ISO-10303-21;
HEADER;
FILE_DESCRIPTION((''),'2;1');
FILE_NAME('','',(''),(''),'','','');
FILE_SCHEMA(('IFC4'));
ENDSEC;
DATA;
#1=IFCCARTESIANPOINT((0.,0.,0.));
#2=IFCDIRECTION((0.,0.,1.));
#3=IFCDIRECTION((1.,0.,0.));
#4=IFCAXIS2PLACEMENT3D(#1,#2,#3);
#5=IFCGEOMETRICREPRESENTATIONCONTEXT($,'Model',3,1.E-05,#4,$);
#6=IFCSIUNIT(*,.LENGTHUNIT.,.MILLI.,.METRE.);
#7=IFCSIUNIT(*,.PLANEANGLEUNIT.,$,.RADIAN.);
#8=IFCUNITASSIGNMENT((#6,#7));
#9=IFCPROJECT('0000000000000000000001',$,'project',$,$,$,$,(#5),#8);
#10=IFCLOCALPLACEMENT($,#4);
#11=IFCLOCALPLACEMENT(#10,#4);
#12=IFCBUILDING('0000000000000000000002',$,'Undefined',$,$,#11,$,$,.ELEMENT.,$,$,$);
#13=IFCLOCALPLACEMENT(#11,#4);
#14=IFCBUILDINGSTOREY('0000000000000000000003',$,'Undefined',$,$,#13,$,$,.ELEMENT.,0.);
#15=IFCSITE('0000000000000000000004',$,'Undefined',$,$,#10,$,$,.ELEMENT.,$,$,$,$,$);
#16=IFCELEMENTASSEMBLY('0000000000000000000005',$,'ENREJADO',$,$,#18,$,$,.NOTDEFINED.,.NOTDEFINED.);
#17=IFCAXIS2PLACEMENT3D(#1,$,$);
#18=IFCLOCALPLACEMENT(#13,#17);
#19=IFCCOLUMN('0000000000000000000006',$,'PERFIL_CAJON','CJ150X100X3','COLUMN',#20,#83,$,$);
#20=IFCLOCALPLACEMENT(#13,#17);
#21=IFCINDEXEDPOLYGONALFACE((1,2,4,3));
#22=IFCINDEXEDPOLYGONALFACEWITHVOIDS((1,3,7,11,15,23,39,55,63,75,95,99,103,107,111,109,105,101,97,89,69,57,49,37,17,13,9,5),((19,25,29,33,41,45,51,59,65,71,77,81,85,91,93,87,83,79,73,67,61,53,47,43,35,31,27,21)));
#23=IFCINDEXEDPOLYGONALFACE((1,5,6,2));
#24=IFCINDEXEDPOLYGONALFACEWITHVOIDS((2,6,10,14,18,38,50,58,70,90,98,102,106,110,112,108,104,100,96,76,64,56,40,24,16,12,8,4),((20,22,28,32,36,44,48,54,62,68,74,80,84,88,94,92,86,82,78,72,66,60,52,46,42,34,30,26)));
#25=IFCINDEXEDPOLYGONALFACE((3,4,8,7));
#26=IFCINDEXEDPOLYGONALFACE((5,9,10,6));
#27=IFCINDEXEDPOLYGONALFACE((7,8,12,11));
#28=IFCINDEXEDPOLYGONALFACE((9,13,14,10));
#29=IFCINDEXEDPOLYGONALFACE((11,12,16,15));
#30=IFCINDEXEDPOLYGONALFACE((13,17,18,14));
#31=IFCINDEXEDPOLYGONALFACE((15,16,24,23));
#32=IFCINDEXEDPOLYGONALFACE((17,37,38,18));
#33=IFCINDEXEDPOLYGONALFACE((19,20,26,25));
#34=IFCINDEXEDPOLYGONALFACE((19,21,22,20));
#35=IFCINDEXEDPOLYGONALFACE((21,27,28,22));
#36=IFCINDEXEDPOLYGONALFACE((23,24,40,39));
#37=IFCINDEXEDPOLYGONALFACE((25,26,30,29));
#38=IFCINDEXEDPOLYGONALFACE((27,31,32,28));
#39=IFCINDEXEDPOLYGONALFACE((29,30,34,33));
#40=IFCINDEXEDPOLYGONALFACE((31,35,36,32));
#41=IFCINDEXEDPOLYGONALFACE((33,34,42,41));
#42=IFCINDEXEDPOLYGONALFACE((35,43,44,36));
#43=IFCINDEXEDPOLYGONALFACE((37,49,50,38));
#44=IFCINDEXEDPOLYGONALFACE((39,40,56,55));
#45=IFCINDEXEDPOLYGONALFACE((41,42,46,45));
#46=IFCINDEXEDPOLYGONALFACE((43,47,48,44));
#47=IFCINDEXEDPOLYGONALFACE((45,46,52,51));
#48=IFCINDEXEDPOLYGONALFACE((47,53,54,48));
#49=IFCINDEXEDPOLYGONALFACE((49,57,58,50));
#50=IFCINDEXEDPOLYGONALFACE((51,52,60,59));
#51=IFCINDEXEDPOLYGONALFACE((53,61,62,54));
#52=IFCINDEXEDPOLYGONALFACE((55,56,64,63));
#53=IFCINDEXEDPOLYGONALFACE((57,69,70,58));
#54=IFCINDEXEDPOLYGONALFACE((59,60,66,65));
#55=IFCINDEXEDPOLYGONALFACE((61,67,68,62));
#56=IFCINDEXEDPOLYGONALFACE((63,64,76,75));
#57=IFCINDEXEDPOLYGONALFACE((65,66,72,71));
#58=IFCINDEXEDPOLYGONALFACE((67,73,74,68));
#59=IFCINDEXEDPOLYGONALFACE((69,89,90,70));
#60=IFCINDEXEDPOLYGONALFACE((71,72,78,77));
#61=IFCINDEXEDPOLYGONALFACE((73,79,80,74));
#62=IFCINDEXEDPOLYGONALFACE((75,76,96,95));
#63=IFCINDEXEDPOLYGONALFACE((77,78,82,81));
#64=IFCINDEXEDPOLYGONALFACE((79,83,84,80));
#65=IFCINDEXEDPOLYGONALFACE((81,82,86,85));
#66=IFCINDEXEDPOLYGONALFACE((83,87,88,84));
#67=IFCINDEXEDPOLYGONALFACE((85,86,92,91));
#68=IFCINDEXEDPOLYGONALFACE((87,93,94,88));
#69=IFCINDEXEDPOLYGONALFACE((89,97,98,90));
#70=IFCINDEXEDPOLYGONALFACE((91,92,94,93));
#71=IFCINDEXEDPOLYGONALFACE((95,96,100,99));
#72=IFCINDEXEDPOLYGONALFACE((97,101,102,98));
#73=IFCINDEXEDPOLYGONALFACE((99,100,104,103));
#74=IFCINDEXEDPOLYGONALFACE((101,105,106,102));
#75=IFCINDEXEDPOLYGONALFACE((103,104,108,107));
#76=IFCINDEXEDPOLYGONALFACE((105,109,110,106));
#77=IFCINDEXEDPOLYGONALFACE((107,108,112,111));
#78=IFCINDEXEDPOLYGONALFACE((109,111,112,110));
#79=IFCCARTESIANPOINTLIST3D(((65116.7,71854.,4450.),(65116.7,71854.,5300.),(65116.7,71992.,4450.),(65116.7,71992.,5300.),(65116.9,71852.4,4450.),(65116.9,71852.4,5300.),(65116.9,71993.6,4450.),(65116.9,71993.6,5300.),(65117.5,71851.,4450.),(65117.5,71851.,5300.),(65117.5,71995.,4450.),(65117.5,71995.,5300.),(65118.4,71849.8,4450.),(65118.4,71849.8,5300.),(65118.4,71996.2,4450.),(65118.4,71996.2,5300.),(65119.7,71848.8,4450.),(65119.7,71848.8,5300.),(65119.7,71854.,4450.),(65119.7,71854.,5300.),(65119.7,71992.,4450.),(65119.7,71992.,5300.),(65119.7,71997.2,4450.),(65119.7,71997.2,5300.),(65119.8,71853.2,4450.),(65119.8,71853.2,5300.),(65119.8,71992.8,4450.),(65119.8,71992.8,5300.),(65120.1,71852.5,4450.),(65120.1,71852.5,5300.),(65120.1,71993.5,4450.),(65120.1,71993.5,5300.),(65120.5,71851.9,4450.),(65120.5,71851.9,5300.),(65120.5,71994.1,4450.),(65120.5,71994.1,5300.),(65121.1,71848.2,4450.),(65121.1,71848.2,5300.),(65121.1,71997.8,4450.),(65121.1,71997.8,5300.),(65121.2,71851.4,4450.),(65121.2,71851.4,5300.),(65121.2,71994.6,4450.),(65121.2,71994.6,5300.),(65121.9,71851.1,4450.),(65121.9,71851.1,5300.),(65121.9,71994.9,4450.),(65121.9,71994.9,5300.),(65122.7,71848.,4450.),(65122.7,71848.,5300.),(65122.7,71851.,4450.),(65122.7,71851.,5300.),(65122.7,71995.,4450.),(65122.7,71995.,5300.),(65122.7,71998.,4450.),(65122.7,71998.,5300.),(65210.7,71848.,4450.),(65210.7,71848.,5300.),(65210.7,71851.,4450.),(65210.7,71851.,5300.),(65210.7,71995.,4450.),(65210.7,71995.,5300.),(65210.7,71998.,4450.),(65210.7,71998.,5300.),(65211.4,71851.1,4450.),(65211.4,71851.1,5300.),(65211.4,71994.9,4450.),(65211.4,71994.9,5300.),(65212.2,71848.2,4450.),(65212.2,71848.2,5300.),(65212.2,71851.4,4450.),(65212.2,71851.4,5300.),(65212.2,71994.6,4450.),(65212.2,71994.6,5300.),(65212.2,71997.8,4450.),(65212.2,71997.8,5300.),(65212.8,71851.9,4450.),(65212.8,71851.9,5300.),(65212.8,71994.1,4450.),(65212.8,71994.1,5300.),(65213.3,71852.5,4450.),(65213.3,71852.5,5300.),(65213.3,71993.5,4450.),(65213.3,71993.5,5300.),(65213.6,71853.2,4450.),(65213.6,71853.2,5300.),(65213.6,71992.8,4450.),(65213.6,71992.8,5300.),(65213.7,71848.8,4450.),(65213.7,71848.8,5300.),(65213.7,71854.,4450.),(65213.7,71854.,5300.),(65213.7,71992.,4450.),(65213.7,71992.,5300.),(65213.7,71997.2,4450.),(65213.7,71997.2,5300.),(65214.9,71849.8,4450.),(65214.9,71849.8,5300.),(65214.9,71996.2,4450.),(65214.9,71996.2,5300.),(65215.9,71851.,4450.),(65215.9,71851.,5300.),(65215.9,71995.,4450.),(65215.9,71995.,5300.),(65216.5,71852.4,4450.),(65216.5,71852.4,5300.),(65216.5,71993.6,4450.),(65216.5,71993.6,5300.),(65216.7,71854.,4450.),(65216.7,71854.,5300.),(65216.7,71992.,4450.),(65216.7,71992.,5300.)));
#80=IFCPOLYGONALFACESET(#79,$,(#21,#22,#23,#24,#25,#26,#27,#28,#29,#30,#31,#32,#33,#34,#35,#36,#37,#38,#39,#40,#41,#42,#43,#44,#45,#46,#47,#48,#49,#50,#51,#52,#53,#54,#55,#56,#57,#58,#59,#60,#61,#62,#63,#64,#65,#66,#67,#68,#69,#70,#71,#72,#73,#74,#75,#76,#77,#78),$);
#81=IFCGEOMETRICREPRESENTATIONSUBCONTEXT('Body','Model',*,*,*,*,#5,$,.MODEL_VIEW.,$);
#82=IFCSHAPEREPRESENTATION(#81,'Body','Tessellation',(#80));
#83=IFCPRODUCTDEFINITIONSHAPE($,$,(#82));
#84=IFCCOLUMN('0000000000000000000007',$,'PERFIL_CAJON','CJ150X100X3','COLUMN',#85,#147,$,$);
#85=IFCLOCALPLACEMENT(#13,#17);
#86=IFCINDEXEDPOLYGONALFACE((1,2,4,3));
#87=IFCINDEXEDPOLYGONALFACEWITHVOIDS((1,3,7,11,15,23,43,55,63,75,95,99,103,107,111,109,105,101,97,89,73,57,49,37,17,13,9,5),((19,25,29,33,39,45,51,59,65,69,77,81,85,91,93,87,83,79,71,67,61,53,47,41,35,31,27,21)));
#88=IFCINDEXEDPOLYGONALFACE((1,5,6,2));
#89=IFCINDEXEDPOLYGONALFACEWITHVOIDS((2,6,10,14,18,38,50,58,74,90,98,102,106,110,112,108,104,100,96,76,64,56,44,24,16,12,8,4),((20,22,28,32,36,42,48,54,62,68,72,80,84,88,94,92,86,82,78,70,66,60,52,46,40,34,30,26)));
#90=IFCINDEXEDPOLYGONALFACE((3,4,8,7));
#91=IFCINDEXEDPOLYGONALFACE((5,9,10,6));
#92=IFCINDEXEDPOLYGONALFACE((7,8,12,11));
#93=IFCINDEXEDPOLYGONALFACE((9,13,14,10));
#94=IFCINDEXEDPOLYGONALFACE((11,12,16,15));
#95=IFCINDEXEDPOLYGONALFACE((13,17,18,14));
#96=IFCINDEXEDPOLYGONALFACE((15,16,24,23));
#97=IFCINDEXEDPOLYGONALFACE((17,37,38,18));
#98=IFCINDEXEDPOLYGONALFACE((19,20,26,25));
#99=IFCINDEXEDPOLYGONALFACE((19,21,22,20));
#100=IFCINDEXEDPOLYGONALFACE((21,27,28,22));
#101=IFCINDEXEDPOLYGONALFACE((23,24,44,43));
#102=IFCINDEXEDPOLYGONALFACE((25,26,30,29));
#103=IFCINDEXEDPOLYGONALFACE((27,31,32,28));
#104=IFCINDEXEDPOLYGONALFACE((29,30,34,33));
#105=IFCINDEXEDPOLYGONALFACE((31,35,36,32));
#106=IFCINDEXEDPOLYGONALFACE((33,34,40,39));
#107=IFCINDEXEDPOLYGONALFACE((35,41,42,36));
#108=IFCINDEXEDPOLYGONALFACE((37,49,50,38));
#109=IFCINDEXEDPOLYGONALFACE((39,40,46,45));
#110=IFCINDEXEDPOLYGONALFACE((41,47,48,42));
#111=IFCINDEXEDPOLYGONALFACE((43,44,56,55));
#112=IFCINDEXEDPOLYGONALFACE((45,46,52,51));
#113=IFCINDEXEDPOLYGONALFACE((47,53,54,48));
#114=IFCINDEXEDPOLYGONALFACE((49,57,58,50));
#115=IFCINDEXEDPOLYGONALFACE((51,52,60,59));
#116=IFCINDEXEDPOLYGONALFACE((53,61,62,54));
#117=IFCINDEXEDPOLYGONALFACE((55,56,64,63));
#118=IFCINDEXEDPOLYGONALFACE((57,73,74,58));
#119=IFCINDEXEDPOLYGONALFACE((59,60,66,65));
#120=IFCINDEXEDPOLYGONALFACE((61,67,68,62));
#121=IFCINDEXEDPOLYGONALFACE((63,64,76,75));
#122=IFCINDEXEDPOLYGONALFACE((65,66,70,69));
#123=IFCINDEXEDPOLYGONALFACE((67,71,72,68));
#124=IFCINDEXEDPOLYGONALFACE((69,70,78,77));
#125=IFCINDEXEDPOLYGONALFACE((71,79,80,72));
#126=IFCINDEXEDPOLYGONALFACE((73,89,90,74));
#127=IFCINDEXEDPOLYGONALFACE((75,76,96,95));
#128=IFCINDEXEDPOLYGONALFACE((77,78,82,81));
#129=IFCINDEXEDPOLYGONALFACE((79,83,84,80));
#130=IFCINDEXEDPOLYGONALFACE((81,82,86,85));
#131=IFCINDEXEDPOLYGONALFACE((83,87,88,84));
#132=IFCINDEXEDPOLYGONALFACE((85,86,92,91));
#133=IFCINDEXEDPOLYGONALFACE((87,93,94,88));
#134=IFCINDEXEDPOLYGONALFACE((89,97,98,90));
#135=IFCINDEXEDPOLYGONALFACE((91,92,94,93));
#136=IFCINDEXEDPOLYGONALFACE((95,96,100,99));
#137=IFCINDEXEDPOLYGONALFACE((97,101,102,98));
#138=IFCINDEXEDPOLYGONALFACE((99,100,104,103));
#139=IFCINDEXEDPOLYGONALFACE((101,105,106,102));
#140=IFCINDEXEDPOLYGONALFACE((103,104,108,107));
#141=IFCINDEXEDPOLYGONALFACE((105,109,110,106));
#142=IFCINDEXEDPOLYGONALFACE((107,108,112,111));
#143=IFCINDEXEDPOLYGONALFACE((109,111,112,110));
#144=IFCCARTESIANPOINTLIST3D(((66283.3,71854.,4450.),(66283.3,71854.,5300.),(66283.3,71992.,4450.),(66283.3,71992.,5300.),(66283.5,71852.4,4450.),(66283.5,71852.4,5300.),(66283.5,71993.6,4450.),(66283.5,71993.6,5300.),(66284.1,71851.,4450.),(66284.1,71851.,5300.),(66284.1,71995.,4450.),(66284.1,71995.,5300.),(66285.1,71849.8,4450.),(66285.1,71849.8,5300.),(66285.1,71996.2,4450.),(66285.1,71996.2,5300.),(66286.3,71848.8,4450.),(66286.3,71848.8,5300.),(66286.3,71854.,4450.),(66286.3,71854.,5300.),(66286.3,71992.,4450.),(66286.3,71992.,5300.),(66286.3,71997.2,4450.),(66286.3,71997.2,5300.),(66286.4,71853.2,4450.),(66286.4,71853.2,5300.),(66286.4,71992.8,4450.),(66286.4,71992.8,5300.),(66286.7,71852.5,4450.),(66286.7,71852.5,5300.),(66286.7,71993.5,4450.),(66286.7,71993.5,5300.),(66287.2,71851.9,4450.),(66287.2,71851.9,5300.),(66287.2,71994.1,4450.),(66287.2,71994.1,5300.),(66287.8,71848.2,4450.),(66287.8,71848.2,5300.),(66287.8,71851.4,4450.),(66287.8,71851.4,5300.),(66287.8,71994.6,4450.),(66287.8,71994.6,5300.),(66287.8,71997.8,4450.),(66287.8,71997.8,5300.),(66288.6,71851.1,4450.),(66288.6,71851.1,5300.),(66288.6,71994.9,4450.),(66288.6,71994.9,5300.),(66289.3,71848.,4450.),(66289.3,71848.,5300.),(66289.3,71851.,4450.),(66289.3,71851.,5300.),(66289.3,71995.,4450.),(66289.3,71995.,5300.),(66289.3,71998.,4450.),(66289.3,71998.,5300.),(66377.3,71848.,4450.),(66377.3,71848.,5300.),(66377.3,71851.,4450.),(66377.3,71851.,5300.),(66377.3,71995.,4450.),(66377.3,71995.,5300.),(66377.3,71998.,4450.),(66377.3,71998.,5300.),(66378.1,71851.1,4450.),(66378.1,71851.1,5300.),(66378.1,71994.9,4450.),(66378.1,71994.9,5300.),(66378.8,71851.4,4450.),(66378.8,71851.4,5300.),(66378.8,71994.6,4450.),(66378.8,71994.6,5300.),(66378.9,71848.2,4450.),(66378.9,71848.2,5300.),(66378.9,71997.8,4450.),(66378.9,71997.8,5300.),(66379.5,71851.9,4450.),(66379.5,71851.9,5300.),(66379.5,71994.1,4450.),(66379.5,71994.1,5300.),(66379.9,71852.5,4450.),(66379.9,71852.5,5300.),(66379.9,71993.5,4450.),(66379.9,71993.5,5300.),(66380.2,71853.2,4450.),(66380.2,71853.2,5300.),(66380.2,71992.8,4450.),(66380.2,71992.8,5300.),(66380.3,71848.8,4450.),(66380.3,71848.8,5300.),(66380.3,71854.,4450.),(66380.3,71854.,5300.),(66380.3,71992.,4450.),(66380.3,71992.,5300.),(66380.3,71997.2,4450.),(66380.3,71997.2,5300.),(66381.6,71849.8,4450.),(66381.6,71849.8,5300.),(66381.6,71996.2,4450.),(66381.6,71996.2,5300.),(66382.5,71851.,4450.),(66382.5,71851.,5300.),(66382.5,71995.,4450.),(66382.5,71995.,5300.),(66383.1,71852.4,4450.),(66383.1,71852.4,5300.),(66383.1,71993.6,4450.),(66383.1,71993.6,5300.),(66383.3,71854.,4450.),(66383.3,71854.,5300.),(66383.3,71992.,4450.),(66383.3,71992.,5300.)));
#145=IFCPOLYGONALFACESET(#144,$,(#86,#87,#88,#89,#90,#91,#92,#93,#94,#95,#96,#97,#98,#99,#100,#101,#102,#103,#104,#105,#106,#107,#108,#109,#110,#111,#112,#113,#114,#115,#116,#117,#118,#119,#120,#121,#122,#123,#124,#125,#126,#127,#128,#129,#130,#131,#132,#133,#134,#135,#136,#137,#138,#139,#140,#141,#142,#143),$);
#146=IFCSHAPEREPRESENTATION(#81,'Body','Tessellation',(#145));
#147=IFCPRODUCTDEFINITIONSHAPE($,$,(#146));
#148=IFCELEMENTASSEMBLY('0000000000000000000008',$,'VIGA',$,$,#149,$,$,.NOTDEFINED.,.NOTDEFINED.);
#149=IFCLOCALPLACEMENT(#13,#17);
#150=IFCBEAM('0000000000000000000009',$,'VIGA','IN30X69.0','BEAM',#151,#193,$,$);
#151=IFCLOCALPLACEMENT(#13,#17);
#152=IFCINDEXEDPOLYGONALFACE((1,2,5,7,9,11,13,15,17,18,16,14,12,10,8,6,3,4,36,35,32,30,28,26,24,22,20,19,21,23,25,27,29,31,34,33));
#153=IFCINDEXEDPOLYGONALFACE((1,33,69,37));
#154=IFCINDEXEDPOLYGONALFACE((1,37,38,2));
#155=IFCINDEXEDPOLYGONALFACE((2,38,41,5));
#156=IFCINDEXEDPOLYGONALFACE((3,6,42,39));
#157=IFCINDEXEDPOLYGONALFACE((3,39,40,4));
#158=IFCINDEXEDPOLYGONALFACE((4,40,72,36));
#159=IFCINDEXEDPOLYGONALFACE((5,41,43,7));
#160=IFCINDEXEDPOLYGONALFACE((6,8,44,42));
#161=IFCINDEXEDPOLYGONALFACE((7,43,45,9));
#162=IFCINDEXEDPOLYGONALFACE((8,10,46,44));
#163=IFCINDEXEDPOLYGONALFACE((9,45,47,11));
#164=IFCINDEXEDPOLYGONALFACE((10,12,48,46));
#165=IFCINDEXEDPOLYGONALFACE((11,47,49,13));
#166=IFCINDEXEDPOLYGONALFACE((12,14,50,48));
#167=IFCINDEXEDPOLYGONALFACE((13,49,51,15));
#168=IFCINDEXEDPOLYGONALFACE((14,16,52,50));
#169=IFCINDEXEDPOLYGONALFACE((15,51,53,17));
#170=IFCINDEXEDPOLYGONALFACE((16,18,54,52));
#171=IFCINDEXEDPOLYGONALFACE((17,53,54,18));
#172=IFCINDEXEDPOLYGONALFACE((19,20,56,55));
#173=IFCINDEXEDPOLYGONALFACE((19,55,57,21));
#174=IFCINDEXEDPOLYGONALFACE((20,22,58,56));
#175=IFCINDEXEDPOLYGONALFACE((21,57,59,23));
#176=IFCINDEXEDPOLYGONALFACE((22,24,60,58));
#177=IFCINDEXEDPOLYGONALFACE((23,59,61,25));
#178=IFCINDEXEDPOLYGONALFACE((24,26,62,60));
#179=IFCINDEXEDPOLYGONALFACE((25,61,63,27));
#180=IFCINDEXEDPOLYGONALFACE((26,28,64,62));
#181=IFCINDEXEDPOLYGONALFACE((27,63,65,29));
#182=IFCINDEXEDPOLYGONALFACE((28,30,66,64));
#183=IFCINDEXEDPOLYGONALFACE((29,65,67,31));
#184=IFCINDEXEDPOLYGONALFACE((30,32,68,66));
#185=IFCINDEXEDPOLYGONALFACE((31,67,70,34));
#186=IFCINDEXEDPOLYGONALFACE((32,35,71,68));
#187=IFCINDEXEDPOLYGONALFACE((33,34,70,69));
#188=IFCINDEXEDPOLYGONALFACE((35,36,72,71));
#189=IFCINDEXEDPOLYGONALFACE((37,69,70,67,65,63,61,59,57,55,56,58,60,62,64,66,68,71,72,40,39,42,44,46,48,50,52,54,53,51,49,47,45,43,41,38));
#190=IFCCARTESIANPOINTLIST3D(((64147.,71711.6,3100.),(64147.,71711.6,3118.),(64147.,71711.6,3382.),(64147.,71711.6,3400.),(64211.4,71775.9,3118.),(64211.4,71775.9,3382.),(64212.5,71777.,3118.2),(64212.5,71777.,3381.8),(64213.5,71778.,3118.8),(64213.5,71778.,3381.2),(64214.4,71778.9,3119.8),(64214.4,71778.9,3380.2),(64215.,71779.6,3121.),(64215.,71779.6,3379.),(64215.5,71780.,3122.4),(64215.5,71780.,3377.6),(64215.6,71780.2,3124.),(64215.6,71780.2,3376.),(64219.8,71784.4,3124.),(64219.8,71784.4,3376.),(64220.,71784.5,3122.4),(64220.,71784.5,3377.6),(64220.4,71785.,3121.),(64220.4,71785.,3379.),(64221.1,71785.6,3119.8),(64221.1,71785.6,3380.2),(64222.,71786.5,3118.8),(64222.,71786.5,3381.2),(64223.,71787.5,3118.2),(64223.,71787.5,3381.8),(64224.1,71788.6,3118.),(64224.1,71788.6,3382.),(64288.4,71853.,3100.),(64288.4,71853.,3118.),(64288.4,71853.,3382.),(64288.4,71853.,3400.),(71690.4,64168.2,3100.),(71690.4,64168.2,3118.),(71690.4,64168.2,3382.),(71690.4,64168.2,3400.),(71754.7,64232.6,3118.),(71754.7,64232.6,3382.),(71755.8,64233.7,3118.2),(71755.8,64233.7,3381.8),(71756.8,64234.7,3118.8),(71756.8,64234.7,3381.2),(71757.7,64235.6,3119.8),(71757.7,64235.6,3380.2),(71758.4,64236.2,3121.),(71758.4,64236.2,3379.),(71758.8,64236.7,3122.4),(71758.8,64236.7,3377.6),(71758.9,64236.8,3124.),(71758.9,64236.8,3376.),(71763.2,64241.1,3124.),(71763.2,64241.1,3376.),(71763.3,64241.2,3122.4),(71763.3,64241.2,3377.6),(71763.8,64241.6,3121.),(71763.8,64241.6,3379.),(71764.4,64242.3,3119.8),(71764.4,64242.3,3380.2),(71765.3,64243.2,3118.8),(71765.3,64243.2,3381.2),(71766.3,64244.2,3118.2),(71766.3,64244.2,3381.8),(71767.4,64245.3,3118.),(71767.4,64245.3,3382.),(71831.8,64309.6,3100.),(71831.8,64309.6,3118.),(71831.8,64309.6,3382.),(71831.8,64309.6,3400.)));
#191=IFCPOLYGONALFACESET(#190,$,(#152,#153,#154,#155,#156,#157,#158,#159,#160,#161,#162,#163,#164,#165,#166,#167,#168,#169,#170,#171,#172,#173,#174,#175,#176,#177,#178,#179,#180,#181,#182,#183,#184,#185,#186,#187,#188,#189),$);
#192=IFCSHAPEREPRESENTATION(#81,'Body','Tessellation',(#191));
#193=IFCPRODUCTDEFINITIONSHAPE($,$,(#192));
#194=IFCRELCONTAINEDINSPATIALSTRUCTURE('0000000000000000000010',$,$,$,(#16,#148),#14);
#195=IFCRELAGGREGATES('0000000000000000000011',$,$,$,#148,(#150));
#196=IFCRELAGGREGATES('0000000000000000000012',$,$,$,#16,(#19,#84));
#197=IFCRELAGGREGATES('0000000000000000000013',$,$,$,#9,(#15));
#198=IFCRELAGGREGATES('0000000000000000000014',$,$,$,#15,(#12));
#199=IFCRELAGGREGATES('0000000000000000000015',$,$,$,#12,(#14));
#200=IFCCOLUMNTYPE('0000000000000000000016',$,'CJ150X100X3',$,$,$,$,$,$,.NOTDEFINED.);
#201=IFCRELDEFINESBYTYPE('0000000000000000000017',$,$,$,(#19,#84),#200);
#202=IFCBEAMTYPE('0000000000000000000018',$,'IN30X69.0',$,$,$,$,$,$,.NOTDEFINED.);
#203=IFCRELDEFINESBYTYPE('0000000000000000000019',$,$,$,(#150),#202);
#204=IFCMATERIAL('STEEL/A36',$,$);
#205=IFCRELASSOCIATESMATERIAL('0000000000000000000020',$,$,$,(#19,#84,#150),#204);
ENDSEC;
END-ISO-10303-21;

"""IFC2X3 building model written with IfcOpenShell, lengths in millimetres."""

from ifc_helpers import new_model, si_unit, frame, origin_with_axes, origin_2d_with_axis, place, context, subcontext, project, spatial, hollow_rectangle, i_section, extrude, material, type_object, element, aggregate, save


model = new_model("IFC2X3")

# Units and contexts
model_context = context("Model", 3, precision=1e-05, world=origin_with_axes())
body_context = subcontext(model_context, "Body", "Model", "MODEL_VIEW")
ifc_project = project(units=[si_unit("LENGTHUNIT", "METRE", prefix="MILLI"), si_unit("PLANEANGLEUNIT", "RADIAN")], contexts=[model_context])

# Site, building, storey
site_placement = place(None, origin_with_axes())
site = spatial("IfcSite", under=ifc_project, at=site_placement, Name="Undefined", CompositionType="ELEMENT")
building_placement = place(site_placement, origin_with_axes())
building = spatial("IfcBuilding", under=site, at=building_placement, Name="Undefined", CompositionType="ELEMENT")
storey_placement = place(building_placement, origin_with_axes())
storey = spatial("IfcBuildingStorey", under=building, at=storey_placement, Name="Undefined", CompositionType="ELEMENT", Elevation=0.0)

# Element assembly, columns
assembly_1_placement = place(storey_placement, origin_with_axes())
assembly_1 = element("IfcElementAssembly", 1, at=assembly_1_placement, inside=storey, Name="ENREJADO", AssemblyPlace="NOTDEFINED", PredefinedType="NOTDEFINED")
ifc_material_1 = material(Name="STEEL/A36")
column_type = type_object("IfcColumnType", Name="CJ150X100X3", PredefinedType="NOTDEFINED")
column_1_placement = place(assembly_1_placement, frame((65166.7, 71923.0, 4450.0), z_axis=(0.0, 0.0, 1.0), x_axis=(0.0, 1.0, 0.0)))
column_1 = element("IfcColumn", 2, at=column_1_placement, type_object=column_type, material=ifc_material_1, Name="PERFIL_CAJON", Description="CJ150X100X3", ObjectType="COLUMN", context=body_context, shape_type="SweptSolid", body=[
    extrude(hollow_rectangle(XDim=100.0, YDim=150.0, WallThickness=3.0, InnerFilletRadius=3.0, OuterFilletRadius=6.0, at=origin_2d_with_axis()), frame((0.0, 0.0, 850.0), z_axis=(0.0, 0.0, -1.0), x_axis=(0.0, 1.0, 0.0)), (0.0, 0.0, 1.0), 850.0),
])
column_2_placement = place(assembly_1_placement, frame((66333.3, 71923.0, 4450.0), z_axis=(0.0, 0.0, 1.0), x_axis=(0.0, 1.0, 0.0)))
column_2 = element("IfcColumn", 3, at=column_2_placement, type_object=column_type, material=ifc_material_1, Name="PERFIL_CAJON", Description="CJ150X100X3", ObjectType="COLUMN", context=body_context, shape_type="SweptSolid", body=[
    extrude(hollow_rectangle(XDim=100.0, YDim=150.0, WallThickness=3.0, InnerFilletRadius=3.0, OuterFilletRadius=6.0, at=origin_2d_with_axis()), frame((0.0, 0.0, 850.0), z_axis=(0.0, 0.0, -1.0), x_axis=(0.0, 1.0, 0.0)), (0.0, 0.0, 1.0), 850.0),
])

# Element assembly, beam
assembly_2_placement = place(storey_placement, origin_with_axes())
assembly_2 = element("IfcElementAssembly", 4, at=assembly_2_placement, inside=storey, Name="VIGA", AssemblyPlace="NOTDEFINED", PredefinedType="NOTDEFINED")
beam_type_1 = type_object("IfcBeamType", Name="IN30X69.0", PredefinedType="NOTDEFINED")
beam_1_placement = place(assembly_2_placement, frame((64217.7, 71782.3, 3250.0), z_axis=(0.0, 0.0, 1.0), x_axis=(0.707107, -0.707107, 0.0)))
beam_1 = element("IfcBeam", 5, at=beam_1_placement, type_object=beam_type_1, material=ifc_material_1, Name="VIGA", Description="IN30X69.0", ObjectType="BEAM", context=body_context, shape_type="SweptSolid", body=[
    extrude(i_section(OverallWidth=200.0, OverallDepth=300.0, WebThickness=6.0, FlangeThickness=18.0, FilletRadius=6.0, at=origin_2d_with_axis()), frame((10667.9, 0.0, 0.0), z_axis=(-1.0, 0.0, 0.0), x_axis=(0.0, -1.0, 0.0)), (0.0, 0.0, 1.0), 10667.9),
])
aggregate(assembly_2, [beam_1])

aggregate(assembly_1, [column_1, column_2])

save(model, "model.ifc")
